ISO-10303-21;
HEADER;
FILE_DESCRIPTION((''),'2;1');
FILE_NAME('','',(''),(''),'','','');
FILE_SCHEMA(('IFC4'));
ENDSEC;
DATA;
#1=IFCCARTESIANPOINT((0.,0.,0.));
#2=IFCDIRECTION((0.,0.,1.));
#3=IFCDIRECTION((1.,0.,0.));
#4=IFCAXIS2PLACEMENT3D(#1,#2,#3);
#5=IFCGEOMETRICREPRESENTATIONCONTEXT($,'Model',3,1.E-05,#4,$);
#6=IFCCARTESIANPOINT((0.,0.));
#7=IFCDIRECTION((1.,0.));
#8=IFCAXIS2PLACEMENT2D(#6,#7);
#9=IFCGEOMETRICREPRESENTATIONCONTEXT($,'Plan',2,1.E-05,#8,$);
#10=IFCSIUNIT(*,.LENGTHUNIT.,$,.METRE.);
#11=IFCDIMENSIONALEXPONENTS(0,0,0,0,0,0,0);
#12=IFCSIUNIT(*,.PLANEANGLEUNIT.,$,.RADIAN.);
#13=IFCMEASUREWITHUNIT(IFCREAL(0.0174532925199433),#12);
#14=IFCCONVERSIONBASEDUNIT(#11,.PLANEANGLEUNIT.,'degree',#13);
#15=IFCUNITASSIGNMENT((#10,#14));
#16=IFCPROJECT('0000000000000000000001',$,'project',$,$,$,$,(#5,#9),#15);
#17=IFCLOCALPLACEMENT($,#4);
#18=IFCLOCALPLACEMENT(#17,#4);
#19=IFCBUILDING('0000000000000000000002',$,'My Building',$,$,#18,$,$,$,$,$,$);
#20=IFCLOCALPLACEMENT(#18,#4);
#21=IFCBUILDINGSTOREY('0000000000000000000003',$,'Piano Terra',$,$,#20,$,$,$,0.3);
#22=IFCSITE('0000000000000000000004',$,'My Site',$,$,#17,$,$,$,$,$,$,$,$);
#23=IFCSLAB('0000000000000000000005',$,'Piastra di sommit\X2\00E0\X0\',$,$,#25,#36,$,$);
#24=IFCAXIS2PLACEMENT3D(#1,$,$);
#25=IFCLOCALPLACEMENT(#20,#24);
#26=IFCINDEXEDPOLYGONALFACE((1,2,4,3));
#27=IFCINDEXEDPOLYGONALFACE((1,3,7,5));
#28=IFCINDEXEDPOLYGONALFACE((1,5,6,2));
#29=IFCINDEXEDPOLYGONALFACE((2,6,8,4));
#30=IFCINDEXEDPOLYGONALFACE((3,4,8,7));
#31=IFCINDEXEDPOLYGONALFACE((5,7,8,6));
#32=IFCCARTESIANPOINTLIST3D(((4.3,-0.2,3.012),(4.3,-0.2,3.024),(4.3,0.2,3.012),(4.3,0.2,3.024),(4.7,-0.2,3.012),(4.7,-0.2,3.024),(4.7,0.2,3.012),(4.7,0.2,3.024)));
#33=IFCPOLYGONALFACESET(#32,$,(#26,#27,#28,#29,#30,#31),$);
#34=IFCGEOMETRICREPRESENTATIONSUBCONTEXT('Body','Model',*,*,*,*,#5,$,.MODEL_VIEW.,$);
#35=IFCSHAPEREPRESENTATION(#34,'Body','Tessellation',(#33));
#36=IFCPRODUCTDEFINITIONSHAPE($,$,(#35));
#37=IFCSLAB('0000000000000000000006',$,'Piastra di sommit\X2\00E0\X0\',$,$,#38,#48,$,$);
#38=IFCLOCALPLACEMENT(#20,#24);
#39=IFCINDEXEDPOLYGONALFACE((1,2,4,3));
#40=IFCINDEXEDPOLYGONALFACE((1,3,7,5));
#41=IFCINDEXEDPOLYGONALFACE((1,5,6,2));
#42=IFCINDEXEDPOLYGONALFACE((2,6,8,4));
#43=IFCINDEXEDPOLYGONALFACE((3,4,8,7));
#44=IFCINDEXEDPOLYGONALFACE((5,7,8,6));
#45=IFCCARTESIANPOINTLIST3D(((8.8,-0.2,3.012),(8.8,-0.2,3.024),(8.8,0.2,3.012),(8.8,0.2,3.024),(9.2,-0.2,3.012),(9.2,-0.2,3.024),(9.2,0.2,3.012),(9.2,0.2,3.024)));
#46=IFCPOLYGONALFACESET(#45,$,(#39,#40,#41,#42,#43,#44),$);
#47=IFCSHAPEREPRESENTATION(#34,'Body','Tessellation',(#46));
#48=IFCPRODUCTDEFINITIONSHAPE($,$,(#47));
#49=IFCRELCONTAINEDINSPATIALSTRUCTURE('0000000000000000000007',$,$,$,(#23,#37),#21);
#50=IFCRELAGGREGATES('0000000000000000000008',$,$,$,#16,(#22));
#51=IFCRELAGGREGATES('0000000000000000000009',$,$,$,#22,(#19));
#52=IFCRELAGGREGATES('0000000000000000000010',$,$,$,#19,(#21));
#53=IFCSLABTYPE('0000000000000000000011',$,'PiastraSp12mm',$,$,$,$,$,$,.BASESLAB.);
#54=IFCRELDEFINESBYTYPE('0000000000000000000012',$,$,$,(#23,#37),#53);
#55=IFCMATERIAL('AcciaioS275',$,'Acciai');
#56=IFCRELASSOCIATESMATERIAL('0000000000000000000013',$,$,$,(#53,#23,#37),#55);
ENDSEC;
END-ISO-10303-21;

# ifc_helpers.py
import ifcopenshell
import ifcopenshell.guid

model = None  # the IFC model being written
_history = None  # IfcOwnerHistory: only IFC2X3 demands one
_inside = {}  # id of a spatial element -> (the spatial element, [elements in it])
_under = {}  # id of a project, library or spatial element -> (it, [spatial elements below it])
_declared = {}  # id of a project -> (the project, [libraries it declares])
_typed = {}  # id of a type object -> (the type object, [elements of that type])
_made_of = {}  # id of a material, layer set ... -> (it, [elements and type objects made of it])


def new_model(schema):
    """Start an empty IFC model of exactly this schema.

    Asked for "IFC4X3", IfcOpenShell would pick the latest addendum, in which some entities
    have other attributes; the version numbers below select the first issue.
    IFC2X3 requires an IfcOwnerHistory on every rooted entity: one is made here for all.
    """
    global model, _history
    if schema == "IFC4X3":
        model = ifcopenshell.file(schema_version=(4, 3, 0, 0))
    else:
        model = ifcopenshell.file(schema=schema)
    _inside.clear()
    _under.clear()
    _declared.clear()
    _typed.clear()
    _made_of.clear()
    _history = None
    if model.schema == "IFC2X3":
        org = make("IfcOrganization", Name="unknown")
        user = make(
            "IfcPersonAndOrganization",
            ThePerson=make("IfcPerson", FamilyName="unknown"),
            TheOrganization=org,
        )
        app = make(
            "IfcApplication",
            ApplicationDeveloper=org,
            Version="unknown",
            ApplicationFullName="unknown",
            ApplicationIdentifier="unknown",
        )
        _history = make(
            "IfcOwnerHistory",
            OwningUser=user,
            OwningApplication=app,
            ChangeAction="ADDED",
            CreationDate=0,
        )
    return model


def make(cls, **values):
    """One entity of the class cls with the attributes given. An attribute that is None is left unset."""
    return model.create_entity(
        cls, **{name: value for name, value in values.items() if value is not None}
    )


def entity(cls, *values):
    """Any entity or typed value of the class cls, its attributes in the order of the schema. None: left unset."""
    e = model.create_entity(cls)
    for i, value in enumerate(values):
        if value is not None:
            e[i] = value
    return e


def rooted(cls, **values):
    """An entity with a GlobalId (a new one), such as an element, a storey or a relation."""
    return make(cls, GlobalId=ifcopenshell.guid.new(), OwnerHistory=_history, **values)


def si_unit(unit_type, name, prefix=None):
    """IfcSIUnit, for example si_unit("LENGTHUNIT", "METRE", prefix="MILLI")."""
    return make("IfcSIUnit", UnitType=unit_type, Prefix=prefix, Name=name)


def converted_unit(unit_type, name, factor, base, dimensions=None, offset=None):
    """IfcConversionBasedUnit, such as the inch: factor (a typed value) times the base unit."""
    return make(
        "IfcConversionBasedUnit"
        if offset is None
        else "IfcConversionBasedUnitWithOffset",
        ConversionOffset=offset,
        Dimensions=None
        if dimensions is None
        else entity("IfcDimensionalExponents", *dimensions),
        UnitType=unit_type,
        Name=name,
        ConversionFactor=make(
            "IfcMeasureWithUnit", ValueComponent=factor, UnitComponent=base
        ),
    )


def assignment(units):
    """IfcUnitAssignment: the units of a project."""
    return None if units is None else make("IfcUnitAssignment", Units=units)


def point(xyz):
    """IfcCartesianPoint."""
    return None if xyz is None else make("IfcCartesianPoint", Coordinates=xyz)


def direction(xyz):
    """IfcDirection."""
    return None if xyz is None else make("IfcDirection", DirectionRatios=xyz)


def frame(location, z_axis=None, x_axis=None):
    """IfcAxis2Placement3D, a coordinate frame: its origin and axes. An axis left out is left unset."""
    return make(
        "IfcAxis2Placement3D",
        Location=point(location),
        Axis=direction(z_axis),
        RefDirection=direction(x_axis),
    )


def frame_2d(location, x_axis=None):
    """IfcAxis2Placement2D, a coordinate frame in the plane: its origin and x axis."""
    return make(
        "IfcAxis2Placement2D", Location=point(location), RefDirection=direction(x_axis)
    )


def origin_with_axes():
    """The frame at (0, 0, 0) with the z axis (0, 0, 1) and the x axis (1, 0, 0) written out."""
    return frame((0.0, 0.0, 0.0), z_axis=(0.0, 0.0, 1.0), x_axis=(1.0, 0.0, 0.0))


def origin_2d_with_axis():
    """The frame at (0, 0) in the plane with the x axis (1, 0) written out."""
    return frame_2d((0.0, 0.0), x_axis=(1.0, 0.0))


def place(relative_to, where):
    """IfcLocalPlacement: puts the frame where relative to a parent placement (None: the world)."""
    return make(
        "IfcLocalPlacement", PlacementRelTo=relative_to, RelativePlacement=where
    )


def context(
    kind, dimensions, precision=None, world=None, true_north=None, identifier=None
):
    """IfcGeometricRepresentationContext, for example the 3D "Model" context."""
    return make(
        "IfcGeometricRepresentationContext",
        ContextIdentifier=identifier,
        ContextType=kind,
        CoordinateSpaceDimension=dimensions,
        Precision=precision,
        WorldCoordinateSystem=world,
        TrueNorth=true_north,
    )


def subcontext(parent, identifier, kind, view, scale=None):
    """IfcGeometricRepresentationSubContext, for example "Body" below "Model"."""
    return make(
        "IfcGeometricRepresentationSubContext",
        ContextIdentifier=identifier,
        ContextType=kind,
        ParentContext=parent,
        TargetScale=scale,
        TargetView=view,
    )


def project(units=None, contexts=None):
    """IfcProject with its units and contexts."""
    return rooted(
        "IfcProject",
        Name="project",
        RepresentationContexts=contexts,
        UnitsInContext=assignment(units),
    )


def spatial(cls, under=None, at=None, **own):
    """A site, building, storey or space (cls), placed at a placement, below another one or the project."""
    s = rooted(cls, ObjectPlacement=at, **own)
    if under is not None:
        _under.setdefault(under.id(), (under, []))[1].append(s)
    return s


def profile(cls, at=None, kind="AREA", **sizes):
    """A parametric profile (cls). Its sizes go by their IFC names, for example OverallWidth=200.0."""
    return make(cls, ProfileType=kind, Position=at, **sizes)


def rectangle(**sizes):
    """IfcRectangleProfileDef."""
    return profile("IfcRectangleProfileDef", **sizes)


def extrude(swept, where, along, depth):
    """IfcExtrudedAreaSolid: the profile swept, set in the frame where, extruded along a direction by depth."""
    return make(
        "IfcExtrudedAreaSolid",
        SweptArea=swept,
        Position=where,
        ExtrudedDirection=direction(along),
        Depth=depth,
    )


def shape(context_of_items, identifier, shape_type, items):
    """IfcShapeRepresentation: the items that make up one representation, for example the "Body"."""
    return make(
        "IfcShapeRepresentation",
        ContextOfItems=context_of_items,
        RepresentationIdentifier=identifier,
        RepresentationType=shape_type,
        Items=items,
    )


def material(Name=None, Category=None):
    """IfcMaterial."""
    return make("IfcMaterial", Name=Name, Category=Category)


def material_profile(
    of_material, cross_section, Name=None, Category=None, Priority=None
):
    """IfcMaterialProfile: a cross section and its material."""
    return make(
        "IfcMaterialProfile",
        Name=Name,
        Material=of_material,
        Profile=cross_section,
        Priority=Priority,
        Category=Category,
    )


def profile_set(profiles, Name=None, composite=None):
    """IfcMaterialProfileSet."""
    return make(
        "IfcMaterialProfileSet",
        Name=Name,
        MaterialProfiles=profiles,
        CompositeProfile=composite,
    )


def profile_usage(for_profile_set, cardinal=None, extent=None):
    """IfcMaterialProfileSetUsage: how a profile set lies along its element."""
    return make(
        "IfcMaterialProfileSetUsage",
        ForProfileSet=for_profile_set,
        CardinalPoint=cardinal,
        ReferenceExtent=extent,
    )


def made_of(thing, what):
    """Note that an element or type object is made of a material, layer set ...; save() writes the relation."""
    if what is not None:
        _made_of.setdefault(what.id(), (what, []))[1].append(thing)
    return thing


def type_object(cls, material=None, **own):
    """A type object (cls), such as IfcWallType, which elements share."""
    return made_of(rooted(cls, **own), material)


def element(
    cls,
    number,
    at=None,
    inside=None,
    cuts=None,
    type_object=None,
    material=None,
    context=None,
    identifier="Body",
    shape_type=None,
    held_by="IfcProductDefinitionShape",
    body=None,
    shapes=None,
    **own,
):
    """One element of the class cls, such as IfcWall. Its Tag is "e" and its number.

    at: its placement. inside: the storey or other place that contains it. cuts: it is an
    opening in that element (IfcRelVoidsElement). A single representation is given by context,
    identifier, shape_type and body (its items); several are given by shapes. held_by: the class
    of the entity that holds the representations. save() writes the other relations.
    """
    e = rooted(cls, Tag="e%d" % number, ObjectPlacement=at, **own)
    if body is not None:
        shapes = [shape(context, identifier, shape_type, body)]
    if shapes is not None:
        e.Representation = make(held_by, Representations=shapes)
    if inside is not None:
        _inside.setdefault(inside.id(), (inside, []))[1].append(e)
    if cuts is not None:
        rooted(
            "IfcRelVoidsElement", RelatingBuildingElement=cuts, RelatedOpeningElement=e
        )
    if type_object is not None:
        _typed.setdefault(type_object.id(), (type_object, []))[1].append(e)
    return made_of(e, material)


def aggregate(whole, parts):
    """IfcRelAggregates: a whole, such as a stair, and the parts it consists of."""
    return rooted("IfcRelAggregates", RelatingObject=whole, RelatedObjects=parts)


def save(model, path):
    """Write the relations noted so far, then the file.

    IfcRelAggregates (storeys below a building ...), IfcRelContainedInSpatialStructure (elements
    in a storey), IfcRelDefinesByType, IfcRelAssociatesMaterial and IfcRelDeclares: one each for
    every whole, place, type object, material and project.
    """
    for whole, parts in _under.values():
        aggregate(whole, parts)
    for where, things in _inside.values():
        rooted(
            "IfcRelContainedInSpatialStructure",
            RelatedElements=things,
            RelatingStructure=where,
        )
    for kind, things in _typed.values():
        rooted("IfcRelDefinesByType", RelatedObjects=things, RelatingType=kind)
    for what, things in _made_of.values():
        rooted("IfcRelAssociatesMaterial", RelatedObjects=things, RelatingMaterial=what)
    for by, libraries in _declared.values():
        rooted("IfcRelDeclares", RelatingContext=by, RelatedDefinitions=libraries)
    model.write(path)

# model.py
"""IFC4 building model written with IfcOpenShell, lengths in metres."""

from ifc_helpers import new_model, entity, si_unit, converted_unit, frame, origin_with_axes, origin_2d_with_axis, place, context, subcontext, project, spatial, rectangle, extrude, material, material_profile, profile_set, profile_usage, type_object, element, save


model = new_model("IFC4")

# Units and contexts
model_context = context("Model", 3, precision=1e-05, world=origin_with_axes())
plan_context = context("Plan", 2, precision=1e-05, world=origin_2d_with_axis())
body_context = subcontext(model_context, "Body", "Model", "MODEL_VIEW")
ifc_project = project(units=[si_unit("LENGTHUNIT", "METRE"), converted_unit("PLANEANGLEUNIT", "degree", entity("IfcReal", 0.0174532925199433), si_unit("PLANEANGLEUNIT", "RADIAN"), dimensions=[0, 0, 0, 0, 0, 0, 0])], contexts=[model_context, plan_context])

# Site, building, storey
site_placement = place(None, origin_with_axes())
site = spatial("IfcSite", under=ifc_project, at=site_placement, Name="My Site")
building_placement = place(site_placement, origin_with_axes())
building = spatial("IfcBuilding", under=site, at=building_placement, Name="My Building")
storey_placement = place(building_placement, origin_with_axes())
storey = spatial("IfcBuildingStorey", under=building, at=storey_placement, Name="Piano Terra", Elevation=0.3)

# Slabs
ifc_material_1 = material(Name="AcciaioS275", Category="Acciai")
ifc_material_profile_1 = material_profile(ifc_material_1, rectangle(XDim=0.4, YDim=0.4))
ifc_profile_set_1 = profile_set([ifc_material_profile_1], Name="Piastra40x40")
ifc_profile_usage_1 = profile_usage(ifc_profile_set_1, cardinal=5)
slab_type_1 = type_object("IfcSlabType", Name="PiastraSp12mm", PredefinedType="BASESLAB", material=ifc_profile_set_1)
slab_1_placement = place(storey_placement, frame((4.5, 0.0, 3.012), z_axis=(0.0, 0.0, 1.0), x_axis=(1.0, 0.0, 0.0)))
element("IfcSlab", 1, at=slab_1_placement, inside=storey, type_object=slab_type_1, material=ifc_profile_usage_1, Name="Piastra di sommità", context=body_context, shape_type="SweptSolid", body=[
    extrude(rectangle(XDim=0.4, YDim=0.4), origin_with_axes(), (0.0, 0.0, 1.0), 0.012),
])
ifc_profile_usage_2 = profile_usage(ifc_profile_set_1, cardinal=5)
slab_2_placement = place(storey_placement, frame((9.0, 0.0, 3.012), z_axis=(0.0, 0.0, 1.0), x_axis=(1.0, 0.0, 0.0)))
element("IfcSlab", 2, at=slab_2_placement, inside=storey, type_object=slab_type_1, material=ifc_profile_usage_2, Name="Piastra di sommità", context=body_context, shape_type="SweptSolid", body=[
    extrude(rectangle(XDim=0.4, YDim=0.4), origin_with_axes(), (0.0, 0.0, 1.0), 0.012),
])

save(model, "model.ifc")
